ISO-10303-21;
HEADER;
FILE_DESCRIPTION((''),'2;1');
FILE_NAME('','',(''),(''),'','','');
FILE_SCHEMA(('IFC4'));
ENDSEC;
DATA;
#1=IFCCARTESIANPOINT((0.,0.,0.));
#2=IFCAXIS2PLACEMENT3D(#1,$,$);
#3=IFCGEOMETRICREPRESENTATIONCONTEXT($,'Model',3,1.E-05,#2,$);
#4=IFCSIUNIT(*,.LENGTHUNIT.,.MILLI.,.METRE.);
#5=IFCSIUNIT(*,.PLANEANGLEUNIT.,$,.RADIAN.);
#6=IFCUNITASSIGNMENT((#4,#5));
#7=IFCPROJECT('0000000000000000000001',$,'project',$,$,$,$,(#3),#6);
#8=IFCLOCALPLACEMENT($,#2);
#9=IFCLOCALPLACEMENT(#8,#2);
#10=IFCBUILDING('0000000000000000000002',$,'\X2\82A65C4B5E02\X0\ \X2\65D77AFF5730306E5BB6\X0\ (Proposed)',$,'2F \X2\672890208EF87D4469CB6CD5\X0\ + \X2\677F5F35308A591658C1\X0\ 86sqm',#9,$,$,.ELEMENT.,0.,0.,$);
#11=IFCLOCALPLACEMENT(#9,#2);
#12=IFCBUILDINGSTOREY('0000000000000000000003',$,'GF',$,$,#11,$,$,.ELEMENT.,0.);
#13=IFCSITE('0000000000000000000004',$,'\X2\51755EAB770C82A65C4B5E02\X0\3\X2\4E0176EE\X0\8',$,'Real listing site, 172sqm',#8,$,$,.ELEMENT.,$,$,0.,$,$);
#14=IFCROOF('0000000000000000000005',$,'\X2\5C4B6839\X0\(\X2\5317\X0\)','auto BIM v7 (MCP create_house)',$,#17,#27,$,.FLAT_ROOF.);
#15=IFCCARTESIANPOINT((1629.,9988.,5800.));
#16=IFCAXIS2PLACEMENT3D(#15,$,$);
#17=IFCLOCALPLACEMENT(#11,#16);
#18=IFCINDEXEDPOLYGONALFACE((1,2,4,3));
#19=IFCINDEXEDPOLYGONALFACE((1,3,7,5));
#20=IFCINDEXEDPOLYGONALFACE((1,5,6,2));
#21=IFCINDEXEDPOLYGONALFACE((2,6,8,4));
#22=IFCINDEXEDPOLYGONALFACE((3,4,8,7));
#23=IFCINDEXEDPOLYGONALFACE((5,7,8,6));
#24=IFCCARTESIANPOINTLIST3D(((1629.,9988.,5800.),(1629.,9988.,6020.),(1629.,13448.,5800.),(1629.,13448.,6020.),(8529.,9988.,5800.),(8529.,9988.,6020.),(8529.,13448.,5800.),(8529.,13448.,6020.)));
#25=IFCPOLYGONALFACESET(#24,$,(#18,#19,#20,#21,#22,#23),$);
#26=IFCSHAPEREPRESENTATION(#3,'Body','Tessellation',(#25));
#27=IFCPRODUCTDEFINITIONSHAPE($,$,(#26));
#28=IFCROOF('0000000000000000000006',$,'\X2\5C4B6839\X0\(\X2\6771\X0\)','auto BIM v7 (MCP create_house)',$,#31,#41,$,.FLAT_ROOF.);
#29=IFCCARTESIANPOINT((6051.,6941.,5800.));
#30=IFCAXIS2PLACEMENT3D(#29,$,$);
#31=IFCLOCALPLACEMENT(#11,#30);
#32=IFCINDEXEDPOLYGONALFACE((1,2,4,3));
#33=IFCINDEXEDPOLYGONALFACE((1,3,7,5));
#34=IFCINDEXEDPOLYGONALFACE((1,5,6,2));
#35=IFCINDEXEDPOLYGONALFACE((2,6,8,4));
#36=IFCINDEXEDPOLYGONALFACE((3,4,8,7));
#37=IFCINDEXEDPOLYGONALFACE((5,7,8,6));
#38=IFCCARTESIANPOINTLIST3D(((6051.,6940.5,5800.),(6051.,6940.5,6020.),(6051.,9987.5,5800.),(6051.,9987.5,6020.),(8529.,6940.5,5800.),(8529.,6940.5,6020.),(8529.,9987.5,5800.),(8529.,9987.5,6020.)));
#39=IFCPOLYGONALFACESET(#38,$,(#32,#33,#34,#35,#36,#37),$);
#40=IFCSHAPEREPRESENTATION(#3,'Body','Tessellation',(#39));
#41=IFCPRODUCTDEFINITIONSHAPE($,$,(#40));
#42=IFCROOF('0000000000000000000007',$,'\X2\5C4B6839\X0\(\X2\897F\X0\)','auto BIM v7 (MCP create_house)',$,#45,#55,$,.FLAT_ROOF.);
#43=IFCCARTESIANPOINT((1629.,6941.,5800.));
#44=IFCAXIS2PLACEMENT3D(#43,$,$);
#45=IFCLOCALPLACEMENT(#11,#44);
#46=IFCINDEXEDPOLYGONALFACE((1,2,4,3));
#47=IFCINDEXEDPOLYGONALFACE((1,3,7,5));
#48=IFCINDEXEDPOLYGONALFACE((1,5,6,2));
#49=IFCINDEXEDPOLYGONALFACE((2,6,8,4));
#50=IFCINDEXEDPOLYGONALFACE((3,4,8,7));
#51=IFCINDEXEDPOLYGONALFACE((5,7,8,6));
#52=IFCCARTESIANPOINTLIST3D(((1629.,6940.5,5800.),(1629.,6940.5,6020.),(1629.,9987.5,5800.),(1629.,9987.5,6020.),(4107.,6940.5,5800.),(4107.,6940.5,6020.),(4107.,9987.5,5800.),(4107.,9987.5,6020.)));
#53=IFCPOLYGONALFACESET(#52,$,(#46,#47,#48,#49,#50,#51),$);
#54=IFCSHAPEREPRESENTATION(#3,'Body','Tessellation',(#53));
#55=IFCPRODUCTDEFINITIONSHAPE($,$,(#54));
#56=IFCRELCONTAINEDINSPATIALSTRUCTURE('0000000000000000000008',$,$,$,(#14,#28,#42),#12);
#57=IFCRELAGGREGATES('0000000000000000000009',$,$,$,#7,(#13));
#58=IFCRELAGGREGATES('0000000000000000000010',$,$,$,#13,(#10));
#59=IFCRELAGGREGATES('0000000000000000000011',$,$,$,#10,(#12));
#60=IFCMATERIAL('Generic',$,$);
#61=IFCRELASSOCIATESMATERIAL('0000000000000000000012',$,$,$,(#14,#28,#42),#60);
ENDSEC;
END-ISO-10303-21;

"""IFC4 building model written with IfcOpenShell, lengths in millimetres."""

from ifc_helpers import new_model, si_unit, frame, frame_2d, origin, place, context, project, spatial, rectangle, extrude, material, element, save


model = new_model("IFC4")

# Units and contexts
model_context = context("Model", 3, precision=1e-05, world=origin())
ifc_project = project(units=[si_unit("LENGTHUNIT", "METRE", prefix="MILLI"), si_unit("PLANEANGLEUNIT", "RADIAN")], contexts=[model_context])

# Site, building, storey
site_placement = place(None, origin())
site = spatial("IfcSite", under=ifc_project, at=site_placement, Name="兵庫県芦屋市3丁目8", ObjectType="Real listing site, 172sqm", CompositionType="ELEMENT", RefElevation=0.0)
building_placement = place(site_placement, origin())
building = spatial("IfcBuilding", under=site, at=building_placement, Name="芦屋市 旗竿地の家 (Proposed)", ObjectType="2F 木造軸組構法 + 板張り外壁 86sqm", CompositionType="ELEMENT", ElevationOfRefHeight=0.0, ElevationOfTerrain=0.0)
storey_placement = place(building_placement, origin())
storey = spatial("IfcBuildingStorey", under=building, at=storey_placement, Name="GF", CompositionType="ELEMENT", Elevation=0.0)

# Shared definitions
ifc_material = material(Name="Generic")

# Roofs
roof_1_placement = place(storey_placement, frame((1629.0, 9988.0, 5800.0)))
element("IfcRoof", 1, at=roof_1_placement, inside=storey, material=ifc_material, Name="屋根(北)", Description="auto BIM v7 (MCP create_house)", PredefinedType="FLAT_ROOF", context=model_context, shape_type="SweptSolid", body=[
    extrude(rectangle(XDim=6900.0, YDim=3460.0, at=frame_2d((3450.0, 1730.0))), frame((1629.0, 9988.0, 5800.0)), (0.0, 0.0, 1.0), 220.0),
])
roof_2_placement = place(storey_placement, frame((6051.0, 6941.0, 5800.0)))
element("IfcRoof", 2, at=roof_2_placement, inside=storey, material=ifc_material, Name="屋根(東)", Description="auto BIM v7 (MCP create_house)", PredefinedType="FLAT_ROOF", context=model_context, shape_type="SweptSolid", body=[
    extrude(rectangle(XDim=2478.0, YDim=3047.0, at=frame_2d((1239.0, 1523.0))), frame((6051.0, 6941.0, 5800.0)), (0.0, 0.0, 1.0), 220.0),
])
roof_3_placement = place(storey_placement, frame((1629.0, 6941.0, 5800.0)))
element("IfcRoof", 3, at=roof_3_placement, inside=storey, material=ifc_material, Name="屋根(西)", Description="auto BIM v7 (MCP create_house)", PredefinedType="FLAT_ROOF", context=model_context, shape_type="SweptSolid", body=[
    extrude(rectangle(XDim=2478.0, YDim=3047.0, at=frame_2d((1239.0, 1523.0))), frame((1629.0, 6941.0, 5800.0)), (0.0, 0.0, 1.0), 220.0),
])

save(model, "model.ifc")
